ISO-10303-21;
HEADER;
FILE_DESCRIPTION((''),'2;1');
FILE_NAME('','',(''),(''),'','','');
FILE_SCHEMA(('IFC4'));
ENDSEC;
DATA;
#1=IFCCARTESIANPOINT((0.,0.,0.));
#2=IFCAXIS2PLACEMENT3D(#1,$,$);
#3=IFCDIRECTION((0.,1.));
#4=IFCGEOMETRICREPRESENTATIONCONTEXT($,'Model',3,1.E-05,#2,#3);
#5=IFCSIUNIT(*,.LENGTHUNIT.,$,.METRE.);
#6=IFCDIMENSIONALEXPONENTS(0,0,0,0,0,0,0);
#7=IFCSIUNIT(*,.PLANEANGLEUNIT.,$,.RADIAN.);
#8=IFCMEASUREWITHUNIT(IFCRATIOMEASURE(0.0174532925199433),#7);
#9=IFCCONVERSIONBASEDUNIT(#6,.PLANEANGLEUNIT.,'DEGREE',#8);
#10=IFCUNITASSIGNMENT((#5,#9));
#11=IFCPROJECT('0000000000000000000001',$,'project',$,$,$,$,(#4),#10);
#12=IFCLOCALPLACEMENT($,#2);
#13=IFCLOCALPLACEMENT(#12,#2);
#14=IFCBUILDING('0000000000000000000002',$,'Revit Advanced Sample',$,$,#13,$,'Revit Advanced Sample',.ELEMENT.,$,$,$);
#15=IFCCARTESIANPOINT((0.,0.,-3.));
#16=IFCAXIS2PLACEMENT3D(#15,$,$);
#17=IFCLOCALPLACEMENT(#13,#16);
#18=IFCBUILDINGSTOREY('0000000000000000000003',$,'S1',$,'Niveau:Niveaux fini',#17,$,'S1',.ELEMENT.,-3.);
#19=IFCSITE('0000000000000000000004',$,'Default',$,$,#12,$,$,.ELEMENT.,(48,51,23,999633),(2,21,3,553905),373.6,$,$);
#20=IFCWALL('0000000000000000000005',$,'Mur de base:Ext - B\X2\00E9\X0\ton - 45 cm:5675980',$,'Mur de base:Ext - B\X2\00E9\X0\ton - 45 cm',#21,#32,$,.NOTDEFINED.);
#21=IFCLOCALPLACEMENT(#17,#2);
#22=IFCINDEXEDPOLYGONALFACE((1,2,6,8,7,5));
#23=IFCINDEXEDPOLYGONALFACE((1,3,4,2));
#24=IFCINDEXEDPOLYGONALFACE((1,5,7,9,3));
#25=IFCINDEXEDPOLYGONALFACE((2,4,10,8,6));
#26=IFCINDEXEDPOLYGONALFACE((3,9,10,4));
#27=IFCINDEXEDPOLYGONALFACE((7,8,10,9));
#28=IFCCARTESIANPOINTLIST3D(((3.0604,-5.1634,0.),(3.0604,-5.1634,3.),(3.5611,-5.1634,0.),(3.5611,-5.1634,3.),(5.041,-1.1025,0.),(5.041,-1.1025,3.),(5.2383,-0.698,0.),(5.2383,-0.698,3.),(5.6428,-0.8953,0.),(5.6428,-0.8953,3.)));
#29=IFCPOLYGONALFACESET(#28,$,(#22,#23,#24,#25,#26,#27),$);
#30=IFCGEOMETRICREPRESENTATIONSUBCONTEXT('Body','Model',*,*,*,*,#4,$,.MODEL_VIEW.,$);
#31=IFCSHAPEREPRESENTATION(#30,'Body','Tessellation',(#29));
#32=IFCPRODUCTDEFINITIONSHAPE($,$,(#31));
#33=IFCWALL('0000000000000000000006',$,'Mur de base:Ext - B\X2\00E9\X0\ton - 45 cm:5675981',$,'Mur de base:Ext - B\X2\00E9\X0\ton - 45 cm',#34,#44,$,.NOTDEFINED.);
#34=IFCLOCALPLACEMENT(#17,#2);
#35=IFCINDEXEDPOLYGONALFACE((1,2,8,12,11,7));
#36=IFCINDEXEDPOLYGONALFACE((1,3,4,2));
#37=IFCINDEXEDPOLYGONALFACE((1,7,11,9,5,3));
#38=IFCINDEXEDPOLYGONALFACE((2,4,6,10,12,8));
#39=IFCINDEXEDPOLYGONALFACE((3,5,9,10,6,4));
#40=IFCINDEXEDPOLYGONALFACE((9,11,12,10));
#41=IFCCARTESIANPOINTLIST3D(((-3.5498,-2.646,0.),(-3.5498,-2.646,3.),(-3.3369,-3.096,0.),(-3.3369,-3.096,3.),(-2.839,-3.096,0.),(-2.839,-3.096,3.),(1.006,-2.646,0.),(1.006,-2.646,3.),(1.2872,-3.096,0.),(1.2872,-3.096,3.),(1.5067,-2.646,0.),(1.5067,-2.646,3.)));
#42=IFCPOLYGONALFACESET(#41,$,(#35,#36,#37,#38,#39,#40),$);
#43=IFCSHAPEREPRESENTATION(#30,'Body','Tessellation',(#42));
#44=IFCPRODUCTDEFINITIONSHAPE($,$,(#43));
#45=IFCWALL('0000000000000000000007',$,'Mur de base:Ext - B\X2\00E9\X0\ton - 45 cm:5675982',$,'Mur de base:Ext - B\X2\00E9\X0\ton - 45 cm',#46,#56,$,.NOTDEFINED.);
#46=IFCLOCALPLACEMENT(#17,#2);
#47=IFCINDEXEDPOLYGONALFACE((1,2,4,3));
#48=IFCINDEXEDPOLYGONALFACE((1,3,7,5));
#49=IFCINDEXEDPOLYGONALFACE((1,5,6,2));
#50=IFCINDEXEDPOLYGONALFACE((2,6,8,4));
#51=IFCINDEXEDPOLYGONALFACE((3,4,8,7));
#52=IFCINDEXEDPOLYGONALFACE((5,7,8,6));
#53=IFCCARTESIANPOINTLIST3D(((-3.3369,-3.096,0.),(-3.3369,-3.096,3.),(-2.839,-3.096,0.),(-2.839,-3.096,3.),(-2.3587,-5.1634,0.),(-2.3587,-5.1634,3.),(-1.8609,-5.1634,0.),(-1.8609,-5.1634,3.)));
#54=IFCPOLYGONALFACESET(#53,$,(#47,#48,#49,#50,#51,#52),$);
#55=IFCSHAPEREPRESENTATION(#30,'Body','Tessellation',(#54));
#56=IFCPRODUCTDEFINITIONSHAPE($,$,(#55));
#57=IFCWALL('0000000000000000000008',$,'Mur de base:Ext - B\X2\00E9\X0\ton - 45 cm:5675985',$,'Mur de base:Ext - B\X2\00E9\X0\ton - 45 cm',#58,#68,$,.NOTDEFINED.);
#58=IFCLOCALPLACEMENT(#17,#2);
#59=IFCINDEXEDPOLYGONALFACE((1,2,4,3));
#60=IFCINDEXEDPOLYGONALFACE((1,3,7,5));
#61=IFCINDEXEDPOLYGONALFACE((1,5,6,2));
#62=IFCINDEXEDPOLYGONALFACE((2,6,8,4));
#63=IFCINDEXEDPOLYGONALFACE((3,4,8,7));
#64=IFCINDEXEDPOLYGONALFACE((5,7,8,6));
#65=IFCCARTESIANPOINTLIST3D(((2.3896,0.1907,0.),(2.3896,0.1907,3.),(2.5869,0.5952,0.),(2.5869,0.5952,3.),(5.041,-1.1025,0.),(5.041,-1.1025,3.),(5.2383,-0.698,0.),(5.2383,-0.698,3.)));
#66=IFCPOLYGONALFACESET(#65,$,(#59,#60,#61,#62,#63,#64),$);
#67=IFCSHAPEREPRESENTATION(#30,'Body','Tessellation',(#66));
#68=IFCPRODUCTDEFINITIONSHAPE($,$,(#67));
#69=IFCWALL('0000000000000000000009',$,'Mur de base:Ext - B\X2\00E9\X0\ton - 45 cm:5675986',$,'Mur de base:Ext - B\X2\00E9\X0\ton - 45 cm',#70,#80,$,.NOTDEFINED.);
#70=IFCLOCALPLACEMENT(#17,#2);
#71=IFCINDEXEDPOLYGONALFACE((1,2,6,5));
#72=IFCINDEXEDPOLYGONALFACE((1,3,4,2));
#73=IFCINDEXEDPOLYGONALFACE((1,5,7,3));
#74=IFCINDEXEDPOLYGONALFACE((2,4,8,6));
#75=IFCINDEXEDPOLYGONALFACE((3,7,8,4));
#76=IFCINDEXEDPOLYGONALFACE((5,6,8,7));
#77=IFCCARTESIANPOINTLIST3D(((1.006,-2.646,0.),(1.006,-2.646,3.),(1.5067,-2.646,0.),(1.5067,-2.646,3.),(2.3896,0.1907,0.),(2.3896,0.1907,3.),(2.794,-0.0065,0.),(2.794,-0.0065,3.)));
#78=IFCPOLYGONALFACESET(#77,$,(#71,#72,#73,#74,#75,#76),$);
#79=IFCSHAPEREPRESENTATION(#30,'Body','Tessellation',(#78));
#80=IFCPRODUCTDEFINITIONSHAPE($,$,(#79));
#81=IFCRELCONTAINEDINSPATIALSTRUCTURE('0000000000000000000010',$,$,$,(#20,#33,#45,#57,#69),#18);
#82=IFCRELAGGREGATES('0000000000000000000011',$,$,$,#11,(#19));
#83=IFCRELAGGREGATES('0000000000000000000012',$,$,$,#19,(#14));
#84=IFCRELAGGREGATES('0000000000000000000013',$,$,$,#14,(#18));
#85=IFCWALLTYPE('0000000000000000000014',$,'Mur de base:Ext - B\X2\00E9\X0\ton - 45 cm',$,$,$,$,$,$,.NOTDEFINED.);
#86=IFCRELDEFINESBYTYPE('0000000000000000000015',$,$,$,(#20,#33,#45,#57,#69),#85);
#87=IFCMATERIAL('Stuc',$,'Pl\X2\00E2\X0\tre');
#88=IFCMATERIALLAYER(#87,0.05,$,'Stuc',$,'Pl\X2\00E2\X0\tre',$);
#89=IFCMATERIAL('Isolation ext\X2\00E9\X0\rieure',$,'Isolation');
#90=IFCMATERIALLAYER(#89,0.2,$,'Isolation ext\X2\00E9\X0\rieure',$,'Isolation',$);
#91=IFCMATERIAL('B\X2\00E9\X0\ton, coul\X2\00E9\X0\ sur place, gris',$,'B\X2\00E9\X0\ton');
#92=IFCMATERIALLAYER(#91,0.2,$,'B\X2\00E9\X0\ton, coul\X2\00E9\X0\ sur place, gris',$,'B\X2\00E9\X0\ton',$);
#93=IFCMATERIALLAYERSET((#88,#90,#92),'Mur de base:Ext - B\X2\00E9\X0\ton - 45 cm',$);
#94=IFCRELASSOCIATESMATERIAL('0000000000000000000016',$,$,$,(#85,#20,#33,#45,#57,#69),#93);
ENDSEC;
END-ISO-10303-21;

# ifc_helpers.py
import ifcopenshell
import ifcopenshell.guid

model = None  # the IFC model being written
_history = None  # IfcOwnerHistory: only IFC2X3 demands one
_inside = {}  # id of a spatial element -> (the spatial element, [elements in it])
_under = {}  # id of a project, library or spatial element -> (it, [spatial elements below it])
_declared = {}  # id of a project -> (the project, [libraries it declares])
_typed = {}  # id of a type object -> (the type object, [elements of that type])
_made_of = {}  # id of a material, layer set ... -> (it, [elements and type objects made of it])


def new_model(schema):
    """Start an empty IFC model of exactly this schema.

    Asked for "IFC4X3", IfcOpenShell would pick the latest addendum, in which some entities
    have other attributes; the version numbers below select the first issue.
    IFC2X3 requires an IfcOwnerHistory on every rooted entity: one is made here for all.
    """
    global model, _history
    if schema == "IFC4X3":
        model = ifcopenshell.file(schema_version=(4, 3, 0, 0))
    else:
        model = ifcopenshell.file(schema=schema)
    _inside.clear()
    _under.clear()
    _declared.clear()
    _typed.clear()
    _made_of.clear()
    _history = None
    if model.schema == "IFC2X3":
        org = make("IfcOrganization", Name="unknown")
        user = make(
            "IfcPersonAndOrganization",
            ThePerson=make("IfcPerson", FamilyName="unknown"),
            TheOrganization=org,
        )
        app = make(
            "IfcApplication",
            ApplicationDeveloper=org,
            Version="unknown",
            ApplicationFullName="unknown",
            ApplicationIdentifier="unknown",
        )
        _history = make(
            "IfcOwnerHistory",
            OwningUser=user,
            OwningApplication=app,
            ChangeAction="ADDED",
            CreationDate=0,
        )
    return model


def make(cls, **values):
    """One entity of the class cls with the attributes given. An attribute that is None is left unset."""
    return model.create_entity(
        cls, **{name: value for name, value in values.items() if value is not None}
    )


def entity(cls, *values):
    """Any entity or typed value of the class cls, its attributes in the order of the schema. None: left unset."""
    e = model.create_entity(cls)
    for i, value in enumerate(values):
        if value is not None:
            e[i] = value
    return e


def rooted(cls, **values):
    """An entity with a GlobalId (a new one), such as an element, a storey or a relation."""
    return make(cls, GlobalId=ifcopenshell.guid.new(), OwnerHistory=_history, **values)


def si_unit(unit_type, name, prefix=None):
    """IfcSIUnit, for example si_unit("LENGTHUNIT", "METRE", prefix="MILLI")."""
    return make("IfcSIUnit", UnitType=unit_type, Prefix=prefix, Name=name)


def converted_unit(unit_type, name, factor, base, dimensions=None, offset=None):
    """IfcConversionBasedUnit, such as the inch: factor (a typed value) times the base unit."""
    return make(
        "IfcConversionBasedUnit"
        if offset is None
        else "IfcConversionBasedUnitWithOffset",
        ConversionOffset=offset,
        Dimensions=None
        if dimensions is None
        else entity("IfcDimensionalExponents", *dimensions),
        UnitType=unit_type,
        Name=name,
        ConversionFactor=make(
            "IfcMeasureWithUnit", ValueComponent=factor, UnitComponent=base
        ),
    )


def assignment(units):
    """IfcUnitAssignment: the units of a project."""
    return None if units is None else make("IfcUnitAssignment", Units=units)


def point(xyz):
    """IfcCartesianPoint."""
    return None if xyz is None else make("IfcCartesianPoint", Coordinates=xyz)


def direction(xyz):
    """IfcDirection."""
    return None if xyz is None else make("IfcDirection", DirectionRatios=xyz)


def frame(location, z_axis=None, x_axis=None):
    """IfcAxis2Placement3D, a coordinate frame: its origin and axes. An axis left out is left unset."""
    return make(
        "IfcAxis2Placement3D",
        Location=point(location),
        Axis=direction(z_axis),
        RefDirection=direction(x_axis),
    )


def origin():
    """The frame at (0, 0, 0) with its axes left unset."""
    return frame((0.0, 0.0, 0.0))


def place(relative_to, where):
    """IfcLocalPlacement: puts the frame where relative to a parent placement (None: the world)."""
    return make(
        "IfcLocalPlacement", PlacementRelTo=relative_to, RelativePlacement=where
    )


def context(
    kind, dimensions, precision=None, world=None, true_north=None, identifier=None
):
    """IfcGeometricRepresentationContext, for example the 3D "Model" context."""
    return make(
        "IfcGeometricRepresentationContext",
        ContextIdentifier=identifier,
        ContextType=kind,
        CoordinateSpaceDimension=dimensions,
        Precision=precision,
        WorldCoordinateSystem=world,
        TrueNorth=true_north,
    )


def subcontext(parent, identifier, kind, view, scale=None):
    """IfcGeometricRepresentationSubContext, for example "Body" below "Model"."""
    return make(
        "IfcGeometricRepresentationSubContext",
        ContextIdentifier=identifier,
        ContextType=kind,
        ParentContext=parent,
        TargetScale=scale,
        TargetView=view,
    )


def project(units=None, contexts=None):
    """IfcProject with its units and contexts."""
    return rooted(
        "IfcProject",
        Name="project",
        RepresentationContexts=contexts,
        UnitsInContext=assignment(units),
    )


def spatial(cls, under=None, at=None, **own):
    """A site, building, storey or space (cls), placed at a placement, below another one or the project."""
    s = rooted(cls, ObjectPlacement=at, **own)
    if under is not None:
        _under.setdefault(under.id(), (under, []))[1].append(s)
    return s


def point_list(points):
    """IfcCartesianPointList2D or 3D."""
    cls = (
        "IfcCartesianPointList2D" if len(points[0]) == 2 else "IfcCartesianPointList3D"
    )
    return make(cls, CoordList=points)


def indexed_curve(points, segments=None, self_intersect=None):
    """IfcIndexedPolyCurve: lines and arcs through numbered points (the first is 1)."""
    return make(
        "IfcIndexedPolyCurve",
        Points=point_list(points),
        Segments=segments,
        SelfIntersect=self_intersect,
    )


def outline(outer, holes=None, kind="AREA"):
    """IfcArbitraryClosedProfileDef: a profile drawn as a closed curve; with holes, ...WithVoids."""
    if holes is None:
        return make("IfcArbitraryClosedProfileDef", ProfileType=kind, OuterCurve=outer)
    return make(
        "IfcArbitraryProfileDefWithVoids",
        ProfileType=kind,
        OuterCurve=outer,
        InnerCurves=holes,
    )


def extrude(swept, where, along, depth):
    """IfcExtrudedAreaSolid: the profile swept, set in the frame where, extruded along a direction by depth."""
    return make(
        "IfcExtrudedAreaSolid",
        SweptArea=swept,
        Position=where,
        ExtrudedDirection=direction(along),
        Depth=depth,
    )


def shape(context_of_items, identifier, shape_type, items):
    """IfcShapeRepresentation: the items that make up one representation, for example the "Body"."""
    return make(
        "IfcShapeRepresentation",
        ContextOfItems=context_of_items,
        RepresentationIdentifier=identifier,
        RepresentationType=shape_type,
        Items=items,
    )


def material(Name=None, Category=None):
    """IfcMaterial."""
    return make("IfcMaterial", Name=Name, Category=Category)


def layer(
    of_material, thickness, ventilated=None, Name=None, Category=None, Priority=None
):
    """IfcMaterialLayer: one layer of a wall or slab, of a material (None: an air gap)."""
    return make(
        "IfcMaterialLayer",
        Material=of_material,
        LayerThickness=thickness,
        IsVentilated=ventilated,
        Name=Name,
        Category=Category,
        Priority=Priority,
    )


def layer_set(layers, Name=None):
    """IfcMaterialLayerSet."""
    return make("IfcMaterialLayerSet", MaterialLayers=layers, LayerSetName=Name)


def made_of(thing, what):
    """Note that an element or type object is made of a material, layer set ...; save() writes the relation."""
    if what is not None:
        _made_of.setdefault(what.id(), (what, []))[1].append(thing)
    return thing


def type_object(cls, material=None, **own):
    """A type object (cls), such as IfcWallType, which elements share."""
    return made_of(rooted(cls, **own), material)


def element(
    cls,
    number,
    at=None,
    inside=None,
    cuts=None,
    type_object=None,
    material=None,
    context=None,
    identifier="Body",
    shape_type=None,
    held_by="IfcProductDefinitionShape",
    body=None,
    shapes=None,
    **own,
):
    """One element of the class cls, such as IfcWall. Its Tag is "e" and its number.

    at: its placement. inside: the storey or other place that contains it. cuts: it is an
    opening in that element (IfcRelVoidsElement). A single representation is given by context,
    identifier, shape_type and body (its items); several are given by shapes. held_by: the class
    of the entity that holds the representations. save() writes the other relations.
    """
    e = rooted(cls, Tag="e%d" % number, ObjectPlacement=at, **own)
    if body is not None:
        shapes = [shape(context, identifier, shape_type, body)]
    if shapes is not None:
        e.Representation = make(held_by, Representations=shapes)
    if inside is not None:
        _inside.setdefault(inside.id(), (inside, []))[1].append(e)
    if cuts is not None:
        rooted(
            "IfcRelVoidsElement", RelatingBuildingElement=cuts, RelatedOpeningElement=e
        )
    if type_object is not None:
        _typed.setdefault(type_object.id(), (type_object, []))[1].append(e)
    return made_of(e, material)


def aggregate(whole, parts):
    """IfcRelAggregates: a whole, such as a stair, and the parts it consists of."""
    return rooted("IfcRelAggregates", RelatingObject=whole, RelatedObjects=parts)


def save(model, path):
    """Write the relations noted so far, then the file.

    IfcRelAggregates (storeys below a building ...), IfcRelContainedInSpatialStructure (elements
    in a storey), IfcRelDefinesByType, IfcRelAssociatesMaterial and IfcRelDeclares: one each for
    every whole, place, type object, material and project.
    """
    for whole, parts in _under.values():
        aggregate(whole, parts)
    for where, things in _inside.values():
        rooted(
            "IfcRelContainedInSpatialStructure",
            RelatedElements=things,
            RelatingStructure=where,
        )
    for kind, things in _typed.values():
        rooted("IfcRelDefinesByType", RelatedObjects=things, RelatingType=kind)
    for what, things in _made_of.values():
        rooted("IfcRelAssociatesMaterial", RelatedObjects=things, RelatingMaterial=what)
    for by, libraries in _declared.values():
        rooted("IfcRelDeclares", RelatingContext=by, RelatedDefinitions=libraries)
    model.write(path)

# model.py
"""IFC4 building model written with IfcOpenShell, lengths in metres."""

from ifc_helpers import new_model, entity, si_unit, converted_unit, direction, frame, origin, place, context, subcontext, project, spatial, indexed_curve, outline, extrude, material, layer, layer_set, type_object, element, save


model = new_model("IFC4")

# Units and contexts
model_context = context("Model", 3, precision=1e-05, world=origin(), true_north=direction((0.0, 1.0)))
body_context = subcontext(model_context, "Body", "Model", "MODEL_VIEW")
ifc_project = project(units=[si_unit("LENGTHUNIT", "METRE"), converted_unit("PLANEANGLEUNIT", "DEGREE", entity("IfcRatioMeasure", 0.0174532925199433), si_unit("PLANEANGLEUNIT", "RADIAN"), dimensions=[0, 0, 0, 0, 0, 0, 0])], contexts=[model_context])

# Site, building, storey
site_placement = place(None, origin())
site = spatial("IfcSite", under=ifc_project, at=site_placement, Name="Default", CompositionType="ELEMENT", RefLatitude=(48, 51, 23, 999633), RefLongitude=(2, 21, 3, 553905), RefElevation=373.6)
building_placement = place(site_placement, origin())
building = spatial("IfcBuilding", under=site, at=building_placement, Name="Revit Advanced Sample", LongName="Revit Advanced Sample", CompositionType="ELEMENT")
storey_placement = place(building_placement, frame((0.0, 0.0, -3.0)))
storey = spatial("IfcBuildingStorey", under=building, at=storey_placement, Name="S1", ObjectType="Niveau:Niveaux fini", LongName="S1", CompositionType="ELEMENT", Elevation=-3.0)

# Walls
ifc_material_1 = material(Name="Stuc", Category="Plâtre")
ifc_layer_1 = layer(ifc_material_1, 0.05, Name="Stuc", Category="Plâtre")
ifc_material_2 = material(Name="Isolation extérieure", Category="Isolation")
ifc_layer_2 = layer(ifc_material_2, 0.2, Name="Isolation extérieure", Category="Isolation")
ifc_material_3 = material(Name="Béton, coulé sur place, gris", Category="Béton")
ifc_layer_3 = layer(ifc_material_3, 0.2, Name="Béton, coulé sur place, gris", Category="Béton")
ifc_layer_set_1 = layer_set([ifc_layer_1, ifc_layer_2, ifc_layer_3], Name="Mur de base:Ext - Béton - 45 cm")
wall_type = type_object("IfcWallType", Name="Mur de base:Ext - Béton - 45 cm", PredefinedType="NOTDEFINED", material=ifc_layer_set_1)
wall_1_placement = place(storey_placement, frame((3.2626, -5.262, 0.0), z_axis=(0.0, 0.0, 1.0), x_axis=(0.438371, 0.898794, 0.0)))
element("IfcWall", 1, at=wall_1_placement, inside=storey, type_object=wall_type, material=ifc_layer_set_1, Name="Mur de base:Ext - Béton - 45 cm:5675980", ObjectType="Mur de base:Ext - Béton - 45 cm", PredefinedType="NOTDEFINED", context=body_context, shape_type="SweptSolid", body=[
    extrude(outline(indexed_curve([(4.9682, -0.225), (4.9682, 0.225), (4.5182, 0.225), (0.0, 0.225), (0.2195, -0.225), (4.9682, -0.225)], self_intersect=False)), origin(), (0.0, 0.0, 1.0), 3.0),
])
wall_2_placement = place(storey_placement, frame((1.5067, -2.871, 0.0), z_axis=(0.0, 0.0, 1.0), x_axis=(-1.0, 0.0, 0.0)))
element("IfcWall", 2, at=wall_2_placement, inside=storey, type_object=wall_type, material=ifc_layer_set_1, Name="Mur de base:Ext - Béton - 45 cm:5675981", ObjectType="Mur de base:Ext - Béton - 45 cm", PredefinedType="NOTDEFINED", context=body_context, shape_type="SweptSolid", body=[
    extrude(outline(indexed_curve([(5.0565, -0.225), (4.8435, 0.225), (4.3457, 0.225), (0.2195, 0.225), (0.0, -0.225), (0.5007, -0.225), (5.0565, -0.225)], self_intersect=False)), origin(), (0.0, 0.0, 1.0), 3.0),
])
wall_3_placement = place(storey_placement, frame((-3.1335, -2.9998, 0.0), z_axis=(0.0, 0.0, 1.0), x_axis=(0.427693, -0.903924, 0.0)))
element("IfcWall", 3, at=wall_3_placement, inside=storey, type_object=wall_type, material=ifc_layer_set_1, Name="Mur de base:Ext - Béton - 45 cm:5675982", ObjectType="Mur de base:Ext - Béton - 45 cm", PredefinedType="NOTDEFINED", context=body_context, shape_type="SweptSolid", body=[
    extrude(outline(indexed_curve([(2.2871, -0.225), (2.5, 0.225), (0.2129, 0.225), (0.0, -0.225), (2.2871, -0.225)], self_intersect=False)), origin(), (0.0, 0.0, 1.0), 3.0),
])
wall_4_placement = place(storey_placement, frame((5.1397, -0.9002, 0.0), z_axis=(0.0, 0.0, 1.0), x_axis=(-0.898794, 0.438371, 0.0)))
element("IfcWall", 4, at=wall_4_placement, inside=storey, type_object=wall_type, material=ifc_layer_set_1, Name="Mur de base:Ext - Béton - 45 cm:5675985", ObjectType="Mur de base:Ext - Béton - 45 cm", PredefinedType="NOTDEFINED", context=body_context, shape_type="SweptSolid", body=[
    extrude(outline(indexed_curve([(2.95, 0.225), (0.0, 0.225), (0.0, -0.225), (2.95, -0.225), (2.95, 0.225)], self_intersect=False)), origin(), (0.0, 0.0, 1.0), 3.0),
])
wall_5_placement = place(storey_placement, frame((2.5918, 0.0921, 0.0), z_axis=(0.0, 0.0, 1.0), x_axis=(-0.438371, -0.898794, 0.0)))
element("IfcWall", 5, at=wall_5_placement, inside=storey, type_object=wall_type, material=ifc_layer_set_1, Name="Mur de base:Ext - Béton - 45 cm:5675986", ObjectType="Mur de base:Ext - Béton - 45 cm", PredefinedType="NOTDEFINED", context=body_context, shape_type="SweptSolid", body=[
    extrude(outline(indexed_curve([(3.1562, -0.225), (2.9367, 0.225), (0.0, 0.225), (0.0, -0.225), (3.1562, -0.225)], self_intersect=False)), origin(), (0.0, 0.0, 1.0), 3.0),
])

save(model, "model.ifc")
